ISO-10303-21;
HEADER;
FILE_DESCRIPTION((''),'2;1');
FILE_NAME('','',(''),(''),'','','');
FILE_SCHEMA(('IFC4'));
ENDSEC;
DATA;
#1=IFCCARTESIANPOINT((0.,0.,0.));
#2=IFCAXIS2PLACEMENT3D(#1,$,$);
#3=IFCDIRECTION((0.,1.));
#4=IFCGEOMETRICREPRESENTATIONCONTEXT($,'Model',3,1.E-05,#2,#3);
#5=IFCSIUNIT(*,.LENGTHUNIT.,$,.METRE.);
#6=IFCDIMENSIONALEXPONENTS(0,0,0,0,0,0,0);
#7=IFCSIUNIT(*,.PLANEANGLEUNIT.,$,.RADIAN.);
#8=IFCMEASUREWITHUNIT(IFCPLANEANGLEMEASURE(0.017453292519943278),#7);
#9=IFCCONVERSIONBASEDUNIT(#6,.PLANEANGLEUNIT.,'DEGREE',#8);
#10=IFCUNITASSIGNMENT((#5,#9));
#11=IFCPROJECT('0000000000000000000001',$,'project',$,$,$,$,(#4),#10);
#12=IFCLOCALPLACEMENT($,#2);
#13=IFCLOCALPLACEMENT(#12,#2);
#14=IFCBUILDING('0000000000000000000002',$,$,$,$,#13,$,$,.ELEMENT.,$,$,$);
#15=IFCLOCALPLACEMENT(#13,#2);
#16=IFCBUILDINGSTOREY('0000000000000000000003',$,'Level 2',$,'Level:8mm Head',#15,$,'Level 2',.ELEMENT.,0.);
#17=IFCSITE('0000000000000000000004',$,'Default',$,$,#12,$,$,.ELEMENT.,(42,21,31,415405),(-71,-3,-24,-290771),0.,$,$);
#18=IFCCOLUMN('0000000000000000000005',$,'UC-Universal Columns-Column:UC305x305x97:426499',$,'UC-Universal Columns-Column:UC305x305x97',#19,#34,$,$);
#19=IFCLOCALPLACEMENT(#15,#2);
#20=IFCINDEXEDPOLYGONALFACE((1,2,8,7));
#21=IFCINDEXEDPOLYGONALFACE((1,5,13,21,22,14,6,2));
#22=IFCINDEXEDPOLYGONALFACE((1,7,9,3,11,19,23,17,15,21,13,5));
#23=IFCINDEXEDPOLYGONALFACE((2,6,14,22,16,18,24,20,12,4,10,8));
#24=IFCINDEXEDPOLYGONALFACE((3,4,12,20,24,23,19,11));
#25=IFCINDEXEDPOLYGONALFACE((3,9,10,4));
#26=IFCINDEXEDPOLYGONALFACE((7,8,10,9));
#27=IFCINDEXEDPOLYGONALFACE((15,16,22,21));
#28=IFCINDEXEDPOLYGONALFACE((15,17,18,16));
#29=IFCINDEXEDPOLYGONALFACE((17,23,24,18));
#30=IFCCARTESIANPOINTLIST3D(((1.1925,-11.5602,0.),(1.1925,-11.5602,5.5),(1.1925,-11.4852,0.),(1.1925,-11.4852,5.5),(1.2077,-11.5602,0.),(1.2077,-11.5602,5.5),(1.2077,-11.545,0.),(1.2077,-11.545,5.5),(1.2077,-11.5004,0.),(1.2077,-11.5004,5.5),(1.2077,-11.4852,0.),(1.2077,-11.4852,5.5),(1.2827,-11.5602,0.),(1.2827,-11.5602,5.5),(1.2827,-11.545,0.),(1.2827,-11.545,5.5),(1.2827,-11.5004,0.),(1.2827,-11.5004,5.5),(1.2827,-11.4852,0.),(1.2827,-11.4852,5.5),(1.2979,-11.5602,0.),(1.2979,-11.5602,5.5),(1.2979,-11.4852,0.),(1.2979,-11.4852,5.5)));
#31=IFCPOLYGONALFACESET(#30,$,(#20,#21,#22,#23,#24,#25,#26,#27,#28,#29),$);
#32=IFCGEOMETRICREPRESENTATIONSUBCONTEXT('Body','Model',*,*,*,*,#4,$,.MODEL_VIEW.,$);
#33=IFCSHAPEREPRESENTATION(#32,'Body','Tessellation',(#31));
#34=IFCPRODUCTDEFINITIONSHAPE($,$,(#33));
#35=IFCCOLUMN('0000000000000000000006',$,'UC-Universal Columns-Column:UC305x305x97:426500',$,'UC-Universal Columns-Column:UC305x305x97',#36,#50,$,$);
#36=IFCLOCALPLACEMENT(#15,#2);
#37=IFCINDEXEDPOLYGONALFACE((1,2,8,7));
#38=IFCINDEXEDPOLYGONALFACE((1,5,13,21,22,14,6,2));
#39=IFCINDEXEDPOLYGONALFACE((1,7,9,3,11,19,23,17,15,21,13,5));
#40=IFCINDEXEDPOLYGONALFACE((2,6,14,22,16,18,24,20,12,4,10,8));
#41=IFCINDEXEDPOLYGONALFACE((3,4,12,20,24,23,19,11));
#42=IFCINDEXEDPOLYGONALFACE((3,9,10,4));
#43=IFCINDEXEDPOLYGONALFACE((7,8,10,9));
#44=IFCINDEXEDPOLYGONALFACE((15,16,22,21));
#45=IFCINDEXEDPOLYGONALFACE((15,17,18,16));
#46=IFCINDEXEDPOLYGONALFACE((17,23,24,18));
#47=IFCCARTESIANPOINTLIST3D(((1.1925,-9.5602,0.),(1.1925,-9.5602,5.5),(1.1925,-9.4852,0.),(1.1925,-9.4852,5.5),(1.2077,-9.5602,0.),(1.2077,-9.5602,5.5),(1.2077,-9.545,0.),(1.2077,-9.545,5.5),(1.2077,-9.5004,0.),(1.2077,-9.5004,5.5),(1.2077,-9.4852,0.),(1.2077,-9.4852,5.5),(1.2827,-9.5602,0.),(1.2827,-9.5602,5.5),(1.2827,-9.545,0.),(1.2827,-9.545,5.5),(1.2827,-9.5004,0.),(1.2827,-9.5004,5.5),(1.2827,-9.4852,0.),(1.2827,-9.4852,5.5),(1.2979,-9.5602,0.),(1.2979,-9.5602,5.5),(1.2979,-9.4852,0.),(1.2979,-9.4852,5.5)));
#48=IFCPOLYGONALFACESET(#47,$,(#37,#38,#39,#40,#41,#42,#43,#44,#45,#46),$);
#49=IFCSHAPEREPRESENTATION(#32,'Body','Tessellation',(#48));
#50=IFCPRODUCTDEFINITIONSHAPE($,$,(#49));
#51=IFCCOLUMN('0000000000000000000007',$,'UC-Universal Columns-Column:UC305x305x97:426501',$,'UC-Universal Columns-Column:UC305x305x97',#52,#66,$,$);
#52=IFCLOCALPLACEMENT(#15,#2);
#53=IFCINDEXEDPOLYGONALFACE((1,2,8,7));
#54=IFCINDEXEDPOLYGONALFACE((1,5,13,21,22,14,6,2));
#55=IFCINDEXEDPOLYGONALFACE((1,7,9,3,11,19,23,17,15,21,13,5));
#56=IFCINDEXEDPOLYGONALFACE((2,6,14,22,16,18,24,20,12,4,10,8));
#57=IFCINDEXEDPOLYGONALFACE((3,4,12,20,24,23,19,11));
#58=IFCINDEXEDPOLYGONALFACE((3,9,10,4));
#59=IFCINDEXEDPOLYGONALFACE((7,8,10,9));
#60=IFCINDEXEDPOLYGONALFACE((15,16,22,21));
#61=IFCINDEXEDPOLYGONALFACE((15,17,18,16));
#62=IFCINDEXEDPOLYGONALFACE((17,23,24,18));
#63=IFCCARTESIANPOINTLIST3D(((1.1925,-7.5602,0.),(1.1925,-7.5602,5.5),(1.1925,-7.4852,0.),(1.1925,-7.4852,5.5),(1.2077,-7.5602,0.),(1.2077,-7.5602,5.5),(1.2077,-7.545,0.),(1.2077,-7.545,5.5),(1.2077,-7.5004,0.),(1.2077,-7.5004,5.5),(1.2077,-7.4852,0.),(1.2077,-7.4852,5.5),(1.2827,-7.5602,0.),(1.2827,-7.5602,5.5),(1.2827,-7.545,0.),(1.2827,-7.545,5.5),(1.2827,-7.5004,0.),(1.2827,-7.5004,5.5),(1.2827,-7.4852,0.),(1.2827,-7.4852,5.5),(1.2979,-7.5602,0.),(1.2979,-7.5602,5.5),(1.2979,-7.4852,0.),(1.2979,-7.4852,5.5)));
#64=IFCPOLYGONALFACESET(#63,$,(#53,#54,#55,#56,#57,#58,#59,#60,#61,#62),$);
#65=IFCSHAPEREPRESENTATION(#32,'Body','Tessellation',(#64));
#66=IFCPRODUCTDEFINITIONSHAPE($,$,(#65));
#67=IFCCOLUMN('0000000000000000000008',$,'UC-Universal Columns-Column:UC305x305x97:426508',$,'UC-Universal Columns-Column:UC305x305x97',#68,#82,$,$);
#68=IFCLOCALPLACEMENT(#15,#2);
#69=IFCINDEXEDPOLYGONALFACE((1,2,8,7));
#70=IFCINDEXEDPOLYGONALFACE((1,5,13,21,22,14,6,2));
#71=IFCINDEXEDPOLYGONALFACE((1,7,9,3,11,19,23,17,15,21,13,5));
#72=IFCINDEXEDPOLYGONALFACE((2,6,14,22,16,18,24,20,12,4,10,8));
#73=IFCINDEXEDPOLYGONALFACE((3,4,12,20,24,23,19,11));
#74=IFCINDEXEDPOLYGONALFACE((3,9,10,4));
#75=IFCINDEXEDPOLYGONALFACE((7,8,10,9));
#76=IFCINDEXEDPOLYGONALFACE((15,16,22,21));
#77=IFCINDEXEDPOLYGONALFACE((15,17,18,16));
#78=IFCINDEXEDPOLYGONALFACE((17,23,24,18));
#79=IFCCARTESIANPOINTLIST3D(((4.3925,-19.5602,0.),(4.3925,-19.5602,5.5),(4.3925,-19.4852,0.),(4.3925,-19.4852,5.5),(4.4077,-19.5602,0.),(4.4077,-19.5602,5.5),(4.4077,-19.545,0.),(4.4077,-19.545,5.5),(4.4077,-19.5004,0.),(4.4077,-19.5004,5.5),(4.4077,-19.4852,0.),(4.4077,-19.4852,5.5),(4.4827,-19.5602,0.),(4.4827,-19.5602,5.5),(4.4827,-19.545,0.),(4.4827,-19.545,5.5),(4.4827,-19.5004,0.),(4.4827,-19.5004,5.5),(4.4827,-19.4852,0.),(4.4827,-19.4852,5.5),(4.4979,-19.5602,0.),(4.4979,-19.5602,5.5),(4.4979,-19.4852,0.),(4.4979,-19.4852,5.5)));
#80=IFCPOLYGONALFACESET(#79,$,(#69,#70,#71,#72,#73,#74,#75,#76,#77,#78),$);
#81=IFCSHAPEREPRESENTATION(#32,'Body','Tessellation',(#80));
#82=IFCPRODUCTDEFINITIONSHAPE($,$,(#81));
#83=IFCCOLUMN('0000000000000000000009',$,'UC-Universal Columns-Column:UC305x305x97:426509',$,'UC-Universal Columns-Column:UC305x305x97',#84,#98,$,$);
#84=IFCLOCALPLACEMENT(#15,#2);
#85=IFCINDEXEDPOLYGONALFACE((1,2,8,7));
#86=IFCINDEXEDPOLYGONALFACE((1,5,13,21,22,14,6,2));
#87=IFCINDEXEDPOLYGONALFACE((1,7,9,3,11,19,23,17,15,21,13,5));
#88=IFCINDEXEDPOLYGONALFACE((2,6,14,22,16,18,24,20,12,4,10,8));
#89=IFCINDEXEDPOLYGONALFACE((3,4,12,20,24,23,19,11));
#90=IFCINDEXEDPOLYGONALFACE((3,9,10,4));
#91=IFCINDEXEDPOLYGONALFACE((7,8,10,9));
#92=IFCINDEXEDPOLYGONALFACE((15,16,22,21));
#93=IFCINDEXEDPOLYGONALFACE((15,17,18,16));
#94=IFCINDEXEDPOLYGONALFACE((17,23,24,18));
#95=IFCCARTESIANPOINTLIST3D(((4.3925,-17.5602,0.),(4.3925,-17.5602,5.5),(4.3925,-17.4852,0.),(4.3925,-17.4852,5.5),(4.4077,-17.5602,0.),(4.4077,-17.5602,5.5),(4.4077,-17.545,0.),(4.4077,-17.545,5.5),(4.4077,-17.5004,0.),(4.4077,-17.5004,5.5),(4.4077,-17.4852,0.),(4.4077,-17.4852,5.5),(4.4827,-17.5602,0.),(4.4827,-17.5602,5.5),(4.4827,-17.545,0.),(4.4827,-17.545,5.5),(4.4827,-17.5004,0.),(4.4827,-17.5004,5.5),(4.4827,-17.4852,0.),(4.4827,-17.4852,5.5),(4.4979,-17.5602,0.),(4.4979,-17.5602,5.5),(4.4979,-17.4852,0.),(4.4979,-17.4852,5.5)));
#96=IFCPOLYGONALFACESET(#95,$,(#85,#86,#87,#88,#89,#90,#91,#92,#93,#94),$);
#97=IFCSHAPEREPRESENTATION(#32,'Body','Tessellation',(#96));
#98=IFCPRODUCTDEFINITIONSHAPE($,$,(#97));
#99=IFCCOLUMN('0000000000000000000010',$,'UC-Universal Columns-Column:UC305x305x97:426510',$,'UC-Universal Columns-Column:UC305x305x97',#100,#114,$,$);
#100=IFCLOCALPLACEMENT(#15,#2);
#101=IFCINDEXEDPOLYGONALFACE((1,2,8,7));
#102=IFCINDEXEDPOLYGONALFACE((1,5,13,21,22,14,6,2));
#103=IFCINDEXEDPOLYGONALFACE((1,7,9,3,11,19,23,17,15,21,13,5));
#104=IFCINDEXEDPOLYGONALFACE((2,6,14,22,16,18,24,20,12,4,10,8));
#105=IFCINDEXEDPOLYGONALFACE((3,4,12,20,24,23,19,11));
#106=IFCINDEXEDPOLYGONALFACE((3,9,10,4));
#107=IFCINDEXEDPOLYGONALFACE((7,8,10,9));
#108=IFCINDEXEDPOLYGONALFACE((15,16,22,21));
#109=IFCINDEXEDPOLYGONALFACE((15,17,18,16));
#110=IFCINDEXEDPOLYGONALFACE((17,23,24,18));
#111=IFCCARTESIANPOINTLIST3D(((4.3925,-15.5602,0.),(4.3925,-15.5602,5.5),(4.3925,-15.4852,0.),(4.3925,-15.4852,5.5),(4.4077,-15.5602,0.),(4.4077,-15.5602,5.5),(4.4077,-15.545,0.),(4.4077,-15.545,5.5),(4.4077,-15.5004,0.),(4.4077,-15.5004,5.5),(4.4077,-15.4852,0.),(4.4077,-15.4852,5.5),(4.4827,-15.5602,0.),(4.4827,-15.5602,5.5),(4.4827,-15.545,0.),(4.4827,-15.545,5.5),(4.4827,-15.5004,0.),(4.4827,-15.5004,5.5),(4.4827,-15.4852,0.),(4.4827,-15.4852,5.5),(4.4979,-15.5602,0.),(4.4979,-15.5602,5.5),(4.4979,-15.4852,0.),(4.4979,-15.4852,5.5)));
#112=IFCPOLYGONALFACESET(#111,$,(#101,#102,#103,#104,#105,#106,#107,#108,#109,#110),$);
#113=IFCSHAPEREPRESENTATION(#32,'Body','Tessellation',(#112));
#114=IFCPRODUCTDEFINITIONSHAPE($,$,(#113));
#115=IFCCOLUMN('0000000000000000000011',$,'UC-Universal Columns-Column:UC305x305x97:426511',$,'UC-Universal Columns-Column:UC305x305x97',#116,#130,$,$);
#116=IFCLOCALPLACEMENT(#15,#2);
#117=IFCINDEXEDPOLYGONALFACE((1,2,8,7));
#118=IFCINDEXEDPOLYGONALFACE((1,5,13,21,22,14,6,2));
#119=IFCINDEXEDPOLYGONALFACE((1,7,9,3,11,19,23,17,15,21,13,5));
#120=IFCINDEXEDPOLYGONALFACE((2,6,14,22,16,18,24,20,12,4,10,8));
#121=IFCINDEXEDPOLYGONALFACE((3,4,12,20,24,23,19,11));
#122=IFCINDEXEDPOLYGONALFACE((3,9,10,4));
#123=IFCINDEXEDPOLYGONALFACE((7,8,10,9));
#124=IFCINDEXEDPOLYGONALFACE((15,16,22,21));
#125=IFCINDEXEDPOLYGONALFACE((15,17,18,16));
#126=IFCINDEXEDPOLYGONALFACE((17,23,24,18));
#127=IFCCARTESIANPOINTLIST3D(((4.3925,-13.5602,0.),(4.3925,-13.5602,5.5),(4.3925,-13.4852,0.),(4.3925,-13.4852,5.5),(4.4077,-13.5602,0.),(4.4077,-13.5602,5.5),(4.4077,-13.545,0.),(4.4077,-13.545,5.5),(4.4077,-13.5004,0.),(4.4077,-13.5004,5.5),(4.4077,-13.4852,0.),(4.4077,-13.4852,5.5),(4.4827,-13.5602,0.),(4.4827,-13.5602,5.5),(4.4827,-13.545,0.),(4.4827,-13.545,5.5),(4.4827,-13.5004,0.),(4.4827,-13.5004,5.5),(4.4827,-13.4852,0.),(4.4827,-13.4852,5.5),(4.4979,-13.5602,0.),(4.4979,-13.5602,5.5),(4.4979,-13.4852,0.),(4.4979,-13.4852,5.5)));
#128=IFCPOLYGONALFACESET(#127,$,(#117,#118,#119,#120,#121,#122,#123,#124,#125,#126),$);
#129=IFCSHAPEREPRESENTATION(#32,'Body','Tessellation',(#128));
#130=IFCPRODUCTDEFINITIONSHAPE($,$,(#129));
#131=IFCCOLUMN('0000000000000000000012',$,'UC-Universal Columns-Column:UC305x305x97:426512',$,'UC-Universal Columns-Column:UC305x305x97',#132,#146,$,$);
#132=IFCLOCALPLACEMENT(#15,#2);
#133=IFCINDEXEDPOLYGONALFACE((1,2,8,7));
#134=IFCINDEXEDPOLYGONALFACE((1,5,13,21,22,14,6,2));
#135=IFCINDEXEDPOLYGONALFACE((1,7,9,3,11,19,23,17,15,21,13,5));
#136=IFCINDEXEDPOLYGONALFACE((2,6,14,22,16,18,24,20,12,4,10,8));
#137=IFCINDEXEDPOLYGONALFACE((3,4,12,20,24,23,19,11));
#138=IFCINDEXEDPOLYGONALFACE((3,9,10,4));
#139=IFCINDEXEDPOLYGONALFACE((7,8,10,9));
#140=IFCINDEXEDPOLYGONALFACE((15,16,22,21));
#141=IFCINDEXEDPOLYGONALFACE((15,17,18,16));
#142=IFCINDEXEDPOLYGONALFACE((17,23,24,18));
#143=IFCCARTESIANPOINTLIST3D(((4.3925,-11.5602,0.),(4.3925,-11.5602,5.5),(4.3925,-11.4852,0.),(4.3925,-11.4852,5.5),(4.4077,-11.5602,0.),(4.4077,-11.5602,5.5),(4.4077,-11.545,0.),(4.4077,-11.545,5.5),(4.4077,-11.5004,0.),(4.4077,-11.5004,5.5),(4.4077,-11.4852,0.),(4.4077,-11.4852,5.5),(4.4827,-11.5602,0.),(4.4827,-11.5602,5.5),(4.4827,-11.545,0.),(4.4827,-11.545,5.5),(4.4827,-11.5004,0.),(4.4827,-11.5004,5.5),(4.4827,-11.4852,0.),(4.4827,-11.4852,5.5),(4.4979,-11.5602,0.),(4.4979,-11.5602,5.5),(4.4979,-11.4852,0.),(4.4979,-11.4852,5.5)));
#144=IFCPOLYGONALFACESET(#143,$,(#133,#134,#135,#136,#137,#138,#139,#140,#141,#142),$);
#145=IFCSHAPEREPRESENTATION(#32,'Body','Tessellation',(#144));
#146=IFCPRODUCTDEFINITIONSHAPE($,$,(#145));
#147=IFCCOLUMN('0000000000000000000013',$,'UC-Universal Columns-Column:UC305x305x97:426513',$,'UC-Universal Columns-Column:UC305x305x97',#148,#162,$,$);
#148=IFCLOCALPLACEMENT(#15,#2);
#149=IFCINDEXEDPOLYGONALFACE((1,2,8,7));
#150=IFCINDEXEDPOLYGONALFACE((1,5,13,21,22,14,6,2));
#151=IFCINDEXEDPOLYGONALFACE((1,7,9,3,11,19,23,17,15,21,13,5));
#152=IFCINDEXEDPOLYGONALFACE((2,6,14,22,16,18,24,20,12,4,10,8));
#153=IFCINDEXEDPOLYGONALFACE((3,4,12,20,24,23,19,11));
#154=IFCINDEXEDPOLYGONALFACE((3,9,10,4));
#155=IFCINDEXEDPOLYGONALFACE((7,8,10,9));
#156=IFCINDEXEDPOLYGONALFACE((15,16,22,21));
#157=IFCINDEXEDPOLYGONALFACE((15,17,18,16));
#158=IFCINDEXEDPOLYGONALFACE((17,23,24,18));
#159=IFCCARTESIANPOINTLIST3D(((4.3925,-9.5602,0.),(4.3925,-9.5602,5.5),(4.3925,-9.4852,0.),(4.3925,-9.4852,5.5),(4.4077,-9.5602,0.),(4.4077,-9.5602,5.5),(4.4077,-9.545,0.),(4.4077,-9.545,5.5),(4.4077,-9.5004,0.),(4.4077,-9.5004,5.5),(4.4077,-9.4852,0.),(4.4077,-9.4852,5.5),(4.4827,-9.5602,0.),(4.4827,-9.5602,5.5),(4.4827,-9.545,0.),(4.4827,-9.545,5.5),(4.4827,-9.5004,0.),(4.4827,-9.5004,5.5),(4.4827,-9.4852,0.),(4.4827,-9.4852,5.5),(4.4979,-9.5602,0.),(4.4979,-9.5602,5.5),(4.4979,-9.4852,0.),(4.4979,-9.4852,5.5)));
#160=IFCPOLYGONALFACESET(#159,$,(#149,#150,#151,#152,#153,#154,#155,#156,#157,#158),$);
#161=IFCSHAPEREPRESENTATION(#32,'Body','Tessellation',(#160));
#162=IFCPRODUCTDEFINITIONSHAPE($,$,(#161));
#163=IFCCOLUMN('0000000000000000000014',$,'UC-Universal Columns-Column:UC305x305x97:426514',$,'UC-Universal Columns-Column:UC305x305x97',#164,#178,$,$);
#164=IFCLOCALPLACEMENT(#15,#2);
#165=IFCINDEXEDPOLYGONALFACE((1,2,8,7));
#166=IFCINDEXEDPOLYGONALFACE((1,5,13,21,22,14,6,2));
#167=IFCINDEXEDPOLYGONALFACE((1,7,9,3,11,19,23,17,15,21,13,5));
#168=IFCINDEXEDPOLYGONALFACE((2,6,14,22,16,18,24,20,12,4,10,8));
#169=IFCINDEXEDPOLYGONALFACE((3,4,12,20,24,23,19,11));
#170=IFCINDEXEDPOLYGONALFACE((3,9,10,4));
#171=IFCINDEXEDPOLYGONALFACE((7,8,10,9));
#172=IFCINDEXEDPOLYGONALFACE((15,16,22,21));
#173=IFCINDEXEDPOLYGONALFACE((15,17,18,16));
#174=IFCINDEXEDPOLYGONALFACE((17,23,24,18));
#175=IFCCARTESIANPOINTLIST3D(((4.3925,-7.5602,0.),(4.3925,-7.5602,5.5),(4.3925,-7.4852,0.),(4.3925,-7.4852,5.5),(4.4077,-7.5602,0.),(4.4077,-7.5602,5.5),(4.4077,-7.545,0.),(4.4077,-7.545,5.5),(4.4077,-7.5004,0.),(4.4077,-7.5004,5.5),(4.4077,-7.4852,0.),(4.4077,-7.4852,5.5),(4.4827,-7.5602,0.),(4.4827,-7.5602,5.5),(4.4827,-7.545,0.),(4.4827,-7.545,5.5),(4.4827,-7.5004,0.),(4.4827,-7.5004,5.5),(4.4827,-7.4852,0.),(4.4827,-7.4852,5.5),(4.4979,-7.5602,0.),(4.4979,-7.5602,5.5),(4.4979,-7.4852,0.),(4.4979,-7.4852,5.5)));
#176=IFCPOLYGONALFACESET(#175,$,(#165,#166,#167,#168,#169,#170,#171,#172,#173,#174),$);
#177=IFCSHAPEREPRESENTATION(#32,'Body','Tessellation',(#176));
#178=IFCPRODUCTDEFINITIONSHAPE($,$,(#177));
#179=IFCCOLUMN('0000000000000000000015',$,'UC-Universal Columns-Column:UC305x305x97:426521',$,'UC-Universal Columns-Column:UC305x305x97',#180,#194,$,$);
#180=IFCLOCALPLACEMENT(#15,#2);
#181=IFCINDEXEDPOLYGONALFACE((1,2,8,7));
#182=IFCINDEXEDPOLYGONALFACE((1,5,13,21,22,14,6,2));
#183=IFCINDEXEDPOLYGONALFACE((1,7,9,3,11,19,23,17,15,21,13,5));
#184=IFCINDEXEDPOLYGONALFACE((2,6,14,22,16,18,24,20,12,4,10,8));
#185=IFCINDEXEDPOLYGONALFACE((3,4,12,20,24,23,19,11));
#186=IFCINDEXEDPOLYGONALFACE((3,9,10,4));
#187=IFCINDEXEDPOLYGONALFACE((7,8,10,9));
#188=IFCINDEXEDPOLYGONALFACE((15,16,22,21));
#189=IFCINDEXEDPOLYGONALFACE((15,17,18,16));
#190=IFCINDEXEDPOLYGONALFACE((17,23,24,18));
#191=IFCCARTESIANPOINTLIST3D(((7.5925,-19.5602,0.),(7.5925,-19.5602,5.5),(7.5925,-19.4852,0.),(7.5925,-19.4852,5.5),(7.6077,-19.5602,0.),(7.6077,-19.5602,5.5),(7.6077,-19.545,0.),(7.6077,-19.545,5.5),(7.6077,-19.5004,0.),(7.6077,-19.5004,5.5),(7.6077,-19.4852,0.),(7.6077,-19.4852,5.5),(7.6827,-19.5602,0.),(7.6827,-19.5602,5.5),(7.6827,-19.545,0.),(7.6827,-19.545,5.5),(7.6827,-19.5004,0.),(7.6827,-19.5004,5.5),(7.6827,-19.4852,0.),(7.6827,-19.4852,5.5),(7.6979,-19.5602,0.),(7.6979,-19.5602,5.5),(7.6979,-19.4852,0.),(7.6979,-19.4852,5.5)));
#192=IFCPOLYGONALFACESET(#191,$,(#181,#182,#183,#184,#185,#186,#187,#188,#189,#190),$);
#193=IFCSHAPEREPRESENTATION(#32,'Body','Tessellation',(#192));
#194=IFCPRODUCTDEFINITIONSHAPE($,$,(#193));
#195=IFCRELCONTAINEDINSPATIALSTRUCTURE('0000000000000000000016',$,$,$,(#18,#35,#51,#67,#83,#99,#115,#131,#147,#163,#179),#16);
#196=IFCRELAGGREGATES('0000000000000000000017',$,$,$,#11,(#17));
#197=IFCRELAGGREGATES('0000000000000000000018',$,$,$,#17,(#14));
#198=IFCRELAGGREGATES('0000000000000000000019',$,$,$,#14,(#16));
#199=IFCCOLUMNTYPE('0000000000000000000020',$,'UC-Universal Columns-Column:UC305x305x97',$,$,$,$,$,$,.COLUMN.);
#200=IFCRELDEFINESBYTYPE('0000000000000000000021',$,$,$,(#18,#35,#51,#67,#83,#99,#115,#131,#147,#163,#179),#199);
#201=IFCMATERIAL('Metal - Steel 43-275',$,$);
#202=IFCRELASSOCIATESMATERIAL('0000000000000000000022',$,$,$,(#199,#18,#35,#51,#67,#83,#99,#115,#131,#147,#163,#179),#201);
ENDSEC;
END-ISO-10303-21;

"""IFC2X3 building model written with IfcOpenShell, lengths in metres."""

from ifc_helpers import new_model, entity, si_unit, converted_unit, direction, frame, frame_2d, origin, place, context, subcontext, project, spatial, polyline, circle_curve, parameter, trimmed, segment, composite_curve, outline, extrude, source, transform, mapped, material, type_object, type_shapes, element, save


model = new_model("IFC2X3")

# Units and contexts
model_context = context("Model", 3, precision=1e-05, world=origin(), true_north=direction((0.0, 1.0)))
body_context = subcontext(model_context, "Body", "Model", "MODEL_VIEW")
ifc_project = project(units=[si_unit("LENGTHUNIT", "METRE"), converted_unit("PLANEANGLEUNIT", "DEGREE", entity("IfcPlaneAngleMeasure", 0.017453292519943278), si_unit("PLANEANGLEUNIT", "RADIAN"), dimensions=[0, 0, 0, 0, 0, 0, 0])], contexts=[model_context])

# Site, building, storey
site_placement = place(None, origin())
site = spatial("IfcSite", under=ifc_project, at=site_placement, Name="Default", CompositionType="ELEMENT", RefLatitude=(42, 21, 31, 415405), RefLongitude=(-71, -3, -24, -290771), RefElevation=0.0)
building_placement = place(site_placement, origin())
building = spatial("IfcBuilding", under=site, at=building_placement, CompositionType="ELEMENT")
storey_placement = place(building_placement, origin())
storey = spatial("IfcBuildingStorey", under=building, at=storey_placement, Name="Level 2", ObjectType="Level:8mm Head", LongName="Level 2", CompositionType="ELEMENT", Elevation=0.0)

# Columns
ifc_material = material(Name="Metal - Steel 43-275")
column_type = type_object("IfcColumnType", Name="UC-Universal Columns-Column:UC305x305x97", PredefinedType="COLUMN", material=ifc_material)
shared_shape = source(origin(), body_context, "Body", "SweptSolid", [
    extrude(outline(composite_curve([segment(polyline([(-0.0375, -0.0375), (0.0375, -0.0375)]), True, "CONTINUOUS"), segment(polyline([(0.0375, -0.0375), (0.0527, -0.0375)]), True, "CONTINUOUS"), segment(trimmed(circle_curve(frame_2d((0.0527, -0.0223), x_axis=(-1.0, 0.0)), 0.0152), [parameter(0.0)], [parameter(90.0)], True, "PARAMETER"), False, "CONTINUOUS"), segment(polyline([(0.0375, -0.0223), (0.0375, 0.0223)]), True, "CONTINUOUS"), segment(trimmed(circle_curve(frame_2d((0.0527, 0.0223), x_axis=(-1.0, 0.0)), 0.0152), [parameter(270.0)], [parameter(0.0)], True, "PARAMETER"), False, "CONTINUOUS"), segment(polyline([(0.0527, 0.0375), (0.0375, 0.0375)]), True, "CONTINUOUS"), segment(polyline([(0.0375, 0.0375), (-0.0375, 0.0375)]), True, "CONTINUOUS"), segment(polyline([(-0.0375, 0.0375), (-0.0527, 0.0375)]), True, "CONTINUOUS"), segment(trimmed(circle_curve(frame_2d((-0.0527, 0.0223), x_axis=(-1.0, 0.0)), 0.0152), [parameter(180.0)], [parameter(270.0)], True, "PARAMETER"), False, "CONTINUOUS"), segment(polyline([(-0.0375, 0.0223), (-0.0375, -0.0223)]), True, "CONTINUOUS"), segment(trimmed(circle_curve(frame_2d((-0.0527, -0.0223), x_axis=(-1.0, 0.0)), 0.0152), [parameter(90.0)], [parameter(180.0)], True, "PARAMETER"), False, "CONTINUOUS"), segment(polyline([(-0.0527, -0.0375), (-0.0375, -0.0375)]), True, "CONTINUOUS")], self_intersect=False)), frame((0.0, 0.0, 0.0), z_axis=(0.0, 0.0, 1.0), x_axis=(-1.0, 0.0, 0.0)), (0.0, 0.0, 1.0), 5.5),
])
type_shapes(column_type, [shared_shape])
for number, where, z_axis, x_axis, name in (
    (1, (1.2452, -11.5227, 0.0), (0.0, 0.0, 1.0), (-1.0, 0.0, 0.0), "UC-Universal Columns-Column:UC305x305x97:426499"),
    (2, (1.2452, -9.5227, 0.0), (0.0, 0.0, 1.0), (-1.0, 0.0, 0.0), "UC-Universal Columns-Column:UC305x305x97:426500"),
    (3, (1.2452, -7.5227, 0.0), (0.0, 0.0, 1.0), (-1.0, 0.0, 0.0), "UC-Universal Columns-Column:UC305x305x97:426501"),
    (4, (4.4452, -19.5227, 0.0), (0.0, 0.0, 1.0), (-1.0, 0.0, 0.0), "UC-Universal Columns-Column:UC305x305x97:426508"),
    (5, (4.4452, -17.5227, 0.0), (0.0, 0.0, 1.0), (-1.0, 0.0, 0.0), "UC-Universal Columns-Column:UC305x305x97:426509"),
    (6, (4.4452, -15.5227, 0.0), (0.0, 0.0, 1.0), (-1.0, 0.0, 0.0), "UC-Universal Columns-Column:UC305x305x97:426510"),
    (7, (4.4452, -13.5227, 0.0), (0.0, 0.0, 1.0), (-1.0, 0.0, 0.0), "UC-Universal Columns-Column:UC305x305x97:426511"),
    (8, (4.4452, -11.5227, 0.0), (0.0, 0.0, 1.0), (-1.0, 0.0, 0.0), "UC-Universal Columns-Column:UC305x305x97:426512"),
    (9, (4.4452, -9.5227, 0.0), (0.0, 0.0, 1.0), (-1.0, 0.0, 0.0), "UC-Universal Columns-Column:UC305x305x97:426513"),
    (10, (4.4452, -7.5227, 0.0), (0.0, 0.0, 1.0), (-1.0, 0.0, 0.0), "UC-Universal Columns-Column:UC305x305x97:426514"),
    (11, (7.6452, -19.5227, 0.0), (0.0, 0.0, 1.0), (-1.0, 0.0, 0.0), "UC-Universal Columns-Column:UC305x305x97:426521"),
):
    element("IfcColumn", number, at=place(storey_placement, frame(where, z_axis=z_axis, x_axis=x_axis)), inside=storey, type_object=column_type, material=ifc_material, Name=name, ObjectType="UC-Universal Columns-Column:UC305x305x97", context=body_context, shape_type="MappedRepresentation", body=[
        mapped(shared_shape, transform((0.0, 0.0, 0.0), scale=1.0)),
    ])

save(model, "model.ifc")
